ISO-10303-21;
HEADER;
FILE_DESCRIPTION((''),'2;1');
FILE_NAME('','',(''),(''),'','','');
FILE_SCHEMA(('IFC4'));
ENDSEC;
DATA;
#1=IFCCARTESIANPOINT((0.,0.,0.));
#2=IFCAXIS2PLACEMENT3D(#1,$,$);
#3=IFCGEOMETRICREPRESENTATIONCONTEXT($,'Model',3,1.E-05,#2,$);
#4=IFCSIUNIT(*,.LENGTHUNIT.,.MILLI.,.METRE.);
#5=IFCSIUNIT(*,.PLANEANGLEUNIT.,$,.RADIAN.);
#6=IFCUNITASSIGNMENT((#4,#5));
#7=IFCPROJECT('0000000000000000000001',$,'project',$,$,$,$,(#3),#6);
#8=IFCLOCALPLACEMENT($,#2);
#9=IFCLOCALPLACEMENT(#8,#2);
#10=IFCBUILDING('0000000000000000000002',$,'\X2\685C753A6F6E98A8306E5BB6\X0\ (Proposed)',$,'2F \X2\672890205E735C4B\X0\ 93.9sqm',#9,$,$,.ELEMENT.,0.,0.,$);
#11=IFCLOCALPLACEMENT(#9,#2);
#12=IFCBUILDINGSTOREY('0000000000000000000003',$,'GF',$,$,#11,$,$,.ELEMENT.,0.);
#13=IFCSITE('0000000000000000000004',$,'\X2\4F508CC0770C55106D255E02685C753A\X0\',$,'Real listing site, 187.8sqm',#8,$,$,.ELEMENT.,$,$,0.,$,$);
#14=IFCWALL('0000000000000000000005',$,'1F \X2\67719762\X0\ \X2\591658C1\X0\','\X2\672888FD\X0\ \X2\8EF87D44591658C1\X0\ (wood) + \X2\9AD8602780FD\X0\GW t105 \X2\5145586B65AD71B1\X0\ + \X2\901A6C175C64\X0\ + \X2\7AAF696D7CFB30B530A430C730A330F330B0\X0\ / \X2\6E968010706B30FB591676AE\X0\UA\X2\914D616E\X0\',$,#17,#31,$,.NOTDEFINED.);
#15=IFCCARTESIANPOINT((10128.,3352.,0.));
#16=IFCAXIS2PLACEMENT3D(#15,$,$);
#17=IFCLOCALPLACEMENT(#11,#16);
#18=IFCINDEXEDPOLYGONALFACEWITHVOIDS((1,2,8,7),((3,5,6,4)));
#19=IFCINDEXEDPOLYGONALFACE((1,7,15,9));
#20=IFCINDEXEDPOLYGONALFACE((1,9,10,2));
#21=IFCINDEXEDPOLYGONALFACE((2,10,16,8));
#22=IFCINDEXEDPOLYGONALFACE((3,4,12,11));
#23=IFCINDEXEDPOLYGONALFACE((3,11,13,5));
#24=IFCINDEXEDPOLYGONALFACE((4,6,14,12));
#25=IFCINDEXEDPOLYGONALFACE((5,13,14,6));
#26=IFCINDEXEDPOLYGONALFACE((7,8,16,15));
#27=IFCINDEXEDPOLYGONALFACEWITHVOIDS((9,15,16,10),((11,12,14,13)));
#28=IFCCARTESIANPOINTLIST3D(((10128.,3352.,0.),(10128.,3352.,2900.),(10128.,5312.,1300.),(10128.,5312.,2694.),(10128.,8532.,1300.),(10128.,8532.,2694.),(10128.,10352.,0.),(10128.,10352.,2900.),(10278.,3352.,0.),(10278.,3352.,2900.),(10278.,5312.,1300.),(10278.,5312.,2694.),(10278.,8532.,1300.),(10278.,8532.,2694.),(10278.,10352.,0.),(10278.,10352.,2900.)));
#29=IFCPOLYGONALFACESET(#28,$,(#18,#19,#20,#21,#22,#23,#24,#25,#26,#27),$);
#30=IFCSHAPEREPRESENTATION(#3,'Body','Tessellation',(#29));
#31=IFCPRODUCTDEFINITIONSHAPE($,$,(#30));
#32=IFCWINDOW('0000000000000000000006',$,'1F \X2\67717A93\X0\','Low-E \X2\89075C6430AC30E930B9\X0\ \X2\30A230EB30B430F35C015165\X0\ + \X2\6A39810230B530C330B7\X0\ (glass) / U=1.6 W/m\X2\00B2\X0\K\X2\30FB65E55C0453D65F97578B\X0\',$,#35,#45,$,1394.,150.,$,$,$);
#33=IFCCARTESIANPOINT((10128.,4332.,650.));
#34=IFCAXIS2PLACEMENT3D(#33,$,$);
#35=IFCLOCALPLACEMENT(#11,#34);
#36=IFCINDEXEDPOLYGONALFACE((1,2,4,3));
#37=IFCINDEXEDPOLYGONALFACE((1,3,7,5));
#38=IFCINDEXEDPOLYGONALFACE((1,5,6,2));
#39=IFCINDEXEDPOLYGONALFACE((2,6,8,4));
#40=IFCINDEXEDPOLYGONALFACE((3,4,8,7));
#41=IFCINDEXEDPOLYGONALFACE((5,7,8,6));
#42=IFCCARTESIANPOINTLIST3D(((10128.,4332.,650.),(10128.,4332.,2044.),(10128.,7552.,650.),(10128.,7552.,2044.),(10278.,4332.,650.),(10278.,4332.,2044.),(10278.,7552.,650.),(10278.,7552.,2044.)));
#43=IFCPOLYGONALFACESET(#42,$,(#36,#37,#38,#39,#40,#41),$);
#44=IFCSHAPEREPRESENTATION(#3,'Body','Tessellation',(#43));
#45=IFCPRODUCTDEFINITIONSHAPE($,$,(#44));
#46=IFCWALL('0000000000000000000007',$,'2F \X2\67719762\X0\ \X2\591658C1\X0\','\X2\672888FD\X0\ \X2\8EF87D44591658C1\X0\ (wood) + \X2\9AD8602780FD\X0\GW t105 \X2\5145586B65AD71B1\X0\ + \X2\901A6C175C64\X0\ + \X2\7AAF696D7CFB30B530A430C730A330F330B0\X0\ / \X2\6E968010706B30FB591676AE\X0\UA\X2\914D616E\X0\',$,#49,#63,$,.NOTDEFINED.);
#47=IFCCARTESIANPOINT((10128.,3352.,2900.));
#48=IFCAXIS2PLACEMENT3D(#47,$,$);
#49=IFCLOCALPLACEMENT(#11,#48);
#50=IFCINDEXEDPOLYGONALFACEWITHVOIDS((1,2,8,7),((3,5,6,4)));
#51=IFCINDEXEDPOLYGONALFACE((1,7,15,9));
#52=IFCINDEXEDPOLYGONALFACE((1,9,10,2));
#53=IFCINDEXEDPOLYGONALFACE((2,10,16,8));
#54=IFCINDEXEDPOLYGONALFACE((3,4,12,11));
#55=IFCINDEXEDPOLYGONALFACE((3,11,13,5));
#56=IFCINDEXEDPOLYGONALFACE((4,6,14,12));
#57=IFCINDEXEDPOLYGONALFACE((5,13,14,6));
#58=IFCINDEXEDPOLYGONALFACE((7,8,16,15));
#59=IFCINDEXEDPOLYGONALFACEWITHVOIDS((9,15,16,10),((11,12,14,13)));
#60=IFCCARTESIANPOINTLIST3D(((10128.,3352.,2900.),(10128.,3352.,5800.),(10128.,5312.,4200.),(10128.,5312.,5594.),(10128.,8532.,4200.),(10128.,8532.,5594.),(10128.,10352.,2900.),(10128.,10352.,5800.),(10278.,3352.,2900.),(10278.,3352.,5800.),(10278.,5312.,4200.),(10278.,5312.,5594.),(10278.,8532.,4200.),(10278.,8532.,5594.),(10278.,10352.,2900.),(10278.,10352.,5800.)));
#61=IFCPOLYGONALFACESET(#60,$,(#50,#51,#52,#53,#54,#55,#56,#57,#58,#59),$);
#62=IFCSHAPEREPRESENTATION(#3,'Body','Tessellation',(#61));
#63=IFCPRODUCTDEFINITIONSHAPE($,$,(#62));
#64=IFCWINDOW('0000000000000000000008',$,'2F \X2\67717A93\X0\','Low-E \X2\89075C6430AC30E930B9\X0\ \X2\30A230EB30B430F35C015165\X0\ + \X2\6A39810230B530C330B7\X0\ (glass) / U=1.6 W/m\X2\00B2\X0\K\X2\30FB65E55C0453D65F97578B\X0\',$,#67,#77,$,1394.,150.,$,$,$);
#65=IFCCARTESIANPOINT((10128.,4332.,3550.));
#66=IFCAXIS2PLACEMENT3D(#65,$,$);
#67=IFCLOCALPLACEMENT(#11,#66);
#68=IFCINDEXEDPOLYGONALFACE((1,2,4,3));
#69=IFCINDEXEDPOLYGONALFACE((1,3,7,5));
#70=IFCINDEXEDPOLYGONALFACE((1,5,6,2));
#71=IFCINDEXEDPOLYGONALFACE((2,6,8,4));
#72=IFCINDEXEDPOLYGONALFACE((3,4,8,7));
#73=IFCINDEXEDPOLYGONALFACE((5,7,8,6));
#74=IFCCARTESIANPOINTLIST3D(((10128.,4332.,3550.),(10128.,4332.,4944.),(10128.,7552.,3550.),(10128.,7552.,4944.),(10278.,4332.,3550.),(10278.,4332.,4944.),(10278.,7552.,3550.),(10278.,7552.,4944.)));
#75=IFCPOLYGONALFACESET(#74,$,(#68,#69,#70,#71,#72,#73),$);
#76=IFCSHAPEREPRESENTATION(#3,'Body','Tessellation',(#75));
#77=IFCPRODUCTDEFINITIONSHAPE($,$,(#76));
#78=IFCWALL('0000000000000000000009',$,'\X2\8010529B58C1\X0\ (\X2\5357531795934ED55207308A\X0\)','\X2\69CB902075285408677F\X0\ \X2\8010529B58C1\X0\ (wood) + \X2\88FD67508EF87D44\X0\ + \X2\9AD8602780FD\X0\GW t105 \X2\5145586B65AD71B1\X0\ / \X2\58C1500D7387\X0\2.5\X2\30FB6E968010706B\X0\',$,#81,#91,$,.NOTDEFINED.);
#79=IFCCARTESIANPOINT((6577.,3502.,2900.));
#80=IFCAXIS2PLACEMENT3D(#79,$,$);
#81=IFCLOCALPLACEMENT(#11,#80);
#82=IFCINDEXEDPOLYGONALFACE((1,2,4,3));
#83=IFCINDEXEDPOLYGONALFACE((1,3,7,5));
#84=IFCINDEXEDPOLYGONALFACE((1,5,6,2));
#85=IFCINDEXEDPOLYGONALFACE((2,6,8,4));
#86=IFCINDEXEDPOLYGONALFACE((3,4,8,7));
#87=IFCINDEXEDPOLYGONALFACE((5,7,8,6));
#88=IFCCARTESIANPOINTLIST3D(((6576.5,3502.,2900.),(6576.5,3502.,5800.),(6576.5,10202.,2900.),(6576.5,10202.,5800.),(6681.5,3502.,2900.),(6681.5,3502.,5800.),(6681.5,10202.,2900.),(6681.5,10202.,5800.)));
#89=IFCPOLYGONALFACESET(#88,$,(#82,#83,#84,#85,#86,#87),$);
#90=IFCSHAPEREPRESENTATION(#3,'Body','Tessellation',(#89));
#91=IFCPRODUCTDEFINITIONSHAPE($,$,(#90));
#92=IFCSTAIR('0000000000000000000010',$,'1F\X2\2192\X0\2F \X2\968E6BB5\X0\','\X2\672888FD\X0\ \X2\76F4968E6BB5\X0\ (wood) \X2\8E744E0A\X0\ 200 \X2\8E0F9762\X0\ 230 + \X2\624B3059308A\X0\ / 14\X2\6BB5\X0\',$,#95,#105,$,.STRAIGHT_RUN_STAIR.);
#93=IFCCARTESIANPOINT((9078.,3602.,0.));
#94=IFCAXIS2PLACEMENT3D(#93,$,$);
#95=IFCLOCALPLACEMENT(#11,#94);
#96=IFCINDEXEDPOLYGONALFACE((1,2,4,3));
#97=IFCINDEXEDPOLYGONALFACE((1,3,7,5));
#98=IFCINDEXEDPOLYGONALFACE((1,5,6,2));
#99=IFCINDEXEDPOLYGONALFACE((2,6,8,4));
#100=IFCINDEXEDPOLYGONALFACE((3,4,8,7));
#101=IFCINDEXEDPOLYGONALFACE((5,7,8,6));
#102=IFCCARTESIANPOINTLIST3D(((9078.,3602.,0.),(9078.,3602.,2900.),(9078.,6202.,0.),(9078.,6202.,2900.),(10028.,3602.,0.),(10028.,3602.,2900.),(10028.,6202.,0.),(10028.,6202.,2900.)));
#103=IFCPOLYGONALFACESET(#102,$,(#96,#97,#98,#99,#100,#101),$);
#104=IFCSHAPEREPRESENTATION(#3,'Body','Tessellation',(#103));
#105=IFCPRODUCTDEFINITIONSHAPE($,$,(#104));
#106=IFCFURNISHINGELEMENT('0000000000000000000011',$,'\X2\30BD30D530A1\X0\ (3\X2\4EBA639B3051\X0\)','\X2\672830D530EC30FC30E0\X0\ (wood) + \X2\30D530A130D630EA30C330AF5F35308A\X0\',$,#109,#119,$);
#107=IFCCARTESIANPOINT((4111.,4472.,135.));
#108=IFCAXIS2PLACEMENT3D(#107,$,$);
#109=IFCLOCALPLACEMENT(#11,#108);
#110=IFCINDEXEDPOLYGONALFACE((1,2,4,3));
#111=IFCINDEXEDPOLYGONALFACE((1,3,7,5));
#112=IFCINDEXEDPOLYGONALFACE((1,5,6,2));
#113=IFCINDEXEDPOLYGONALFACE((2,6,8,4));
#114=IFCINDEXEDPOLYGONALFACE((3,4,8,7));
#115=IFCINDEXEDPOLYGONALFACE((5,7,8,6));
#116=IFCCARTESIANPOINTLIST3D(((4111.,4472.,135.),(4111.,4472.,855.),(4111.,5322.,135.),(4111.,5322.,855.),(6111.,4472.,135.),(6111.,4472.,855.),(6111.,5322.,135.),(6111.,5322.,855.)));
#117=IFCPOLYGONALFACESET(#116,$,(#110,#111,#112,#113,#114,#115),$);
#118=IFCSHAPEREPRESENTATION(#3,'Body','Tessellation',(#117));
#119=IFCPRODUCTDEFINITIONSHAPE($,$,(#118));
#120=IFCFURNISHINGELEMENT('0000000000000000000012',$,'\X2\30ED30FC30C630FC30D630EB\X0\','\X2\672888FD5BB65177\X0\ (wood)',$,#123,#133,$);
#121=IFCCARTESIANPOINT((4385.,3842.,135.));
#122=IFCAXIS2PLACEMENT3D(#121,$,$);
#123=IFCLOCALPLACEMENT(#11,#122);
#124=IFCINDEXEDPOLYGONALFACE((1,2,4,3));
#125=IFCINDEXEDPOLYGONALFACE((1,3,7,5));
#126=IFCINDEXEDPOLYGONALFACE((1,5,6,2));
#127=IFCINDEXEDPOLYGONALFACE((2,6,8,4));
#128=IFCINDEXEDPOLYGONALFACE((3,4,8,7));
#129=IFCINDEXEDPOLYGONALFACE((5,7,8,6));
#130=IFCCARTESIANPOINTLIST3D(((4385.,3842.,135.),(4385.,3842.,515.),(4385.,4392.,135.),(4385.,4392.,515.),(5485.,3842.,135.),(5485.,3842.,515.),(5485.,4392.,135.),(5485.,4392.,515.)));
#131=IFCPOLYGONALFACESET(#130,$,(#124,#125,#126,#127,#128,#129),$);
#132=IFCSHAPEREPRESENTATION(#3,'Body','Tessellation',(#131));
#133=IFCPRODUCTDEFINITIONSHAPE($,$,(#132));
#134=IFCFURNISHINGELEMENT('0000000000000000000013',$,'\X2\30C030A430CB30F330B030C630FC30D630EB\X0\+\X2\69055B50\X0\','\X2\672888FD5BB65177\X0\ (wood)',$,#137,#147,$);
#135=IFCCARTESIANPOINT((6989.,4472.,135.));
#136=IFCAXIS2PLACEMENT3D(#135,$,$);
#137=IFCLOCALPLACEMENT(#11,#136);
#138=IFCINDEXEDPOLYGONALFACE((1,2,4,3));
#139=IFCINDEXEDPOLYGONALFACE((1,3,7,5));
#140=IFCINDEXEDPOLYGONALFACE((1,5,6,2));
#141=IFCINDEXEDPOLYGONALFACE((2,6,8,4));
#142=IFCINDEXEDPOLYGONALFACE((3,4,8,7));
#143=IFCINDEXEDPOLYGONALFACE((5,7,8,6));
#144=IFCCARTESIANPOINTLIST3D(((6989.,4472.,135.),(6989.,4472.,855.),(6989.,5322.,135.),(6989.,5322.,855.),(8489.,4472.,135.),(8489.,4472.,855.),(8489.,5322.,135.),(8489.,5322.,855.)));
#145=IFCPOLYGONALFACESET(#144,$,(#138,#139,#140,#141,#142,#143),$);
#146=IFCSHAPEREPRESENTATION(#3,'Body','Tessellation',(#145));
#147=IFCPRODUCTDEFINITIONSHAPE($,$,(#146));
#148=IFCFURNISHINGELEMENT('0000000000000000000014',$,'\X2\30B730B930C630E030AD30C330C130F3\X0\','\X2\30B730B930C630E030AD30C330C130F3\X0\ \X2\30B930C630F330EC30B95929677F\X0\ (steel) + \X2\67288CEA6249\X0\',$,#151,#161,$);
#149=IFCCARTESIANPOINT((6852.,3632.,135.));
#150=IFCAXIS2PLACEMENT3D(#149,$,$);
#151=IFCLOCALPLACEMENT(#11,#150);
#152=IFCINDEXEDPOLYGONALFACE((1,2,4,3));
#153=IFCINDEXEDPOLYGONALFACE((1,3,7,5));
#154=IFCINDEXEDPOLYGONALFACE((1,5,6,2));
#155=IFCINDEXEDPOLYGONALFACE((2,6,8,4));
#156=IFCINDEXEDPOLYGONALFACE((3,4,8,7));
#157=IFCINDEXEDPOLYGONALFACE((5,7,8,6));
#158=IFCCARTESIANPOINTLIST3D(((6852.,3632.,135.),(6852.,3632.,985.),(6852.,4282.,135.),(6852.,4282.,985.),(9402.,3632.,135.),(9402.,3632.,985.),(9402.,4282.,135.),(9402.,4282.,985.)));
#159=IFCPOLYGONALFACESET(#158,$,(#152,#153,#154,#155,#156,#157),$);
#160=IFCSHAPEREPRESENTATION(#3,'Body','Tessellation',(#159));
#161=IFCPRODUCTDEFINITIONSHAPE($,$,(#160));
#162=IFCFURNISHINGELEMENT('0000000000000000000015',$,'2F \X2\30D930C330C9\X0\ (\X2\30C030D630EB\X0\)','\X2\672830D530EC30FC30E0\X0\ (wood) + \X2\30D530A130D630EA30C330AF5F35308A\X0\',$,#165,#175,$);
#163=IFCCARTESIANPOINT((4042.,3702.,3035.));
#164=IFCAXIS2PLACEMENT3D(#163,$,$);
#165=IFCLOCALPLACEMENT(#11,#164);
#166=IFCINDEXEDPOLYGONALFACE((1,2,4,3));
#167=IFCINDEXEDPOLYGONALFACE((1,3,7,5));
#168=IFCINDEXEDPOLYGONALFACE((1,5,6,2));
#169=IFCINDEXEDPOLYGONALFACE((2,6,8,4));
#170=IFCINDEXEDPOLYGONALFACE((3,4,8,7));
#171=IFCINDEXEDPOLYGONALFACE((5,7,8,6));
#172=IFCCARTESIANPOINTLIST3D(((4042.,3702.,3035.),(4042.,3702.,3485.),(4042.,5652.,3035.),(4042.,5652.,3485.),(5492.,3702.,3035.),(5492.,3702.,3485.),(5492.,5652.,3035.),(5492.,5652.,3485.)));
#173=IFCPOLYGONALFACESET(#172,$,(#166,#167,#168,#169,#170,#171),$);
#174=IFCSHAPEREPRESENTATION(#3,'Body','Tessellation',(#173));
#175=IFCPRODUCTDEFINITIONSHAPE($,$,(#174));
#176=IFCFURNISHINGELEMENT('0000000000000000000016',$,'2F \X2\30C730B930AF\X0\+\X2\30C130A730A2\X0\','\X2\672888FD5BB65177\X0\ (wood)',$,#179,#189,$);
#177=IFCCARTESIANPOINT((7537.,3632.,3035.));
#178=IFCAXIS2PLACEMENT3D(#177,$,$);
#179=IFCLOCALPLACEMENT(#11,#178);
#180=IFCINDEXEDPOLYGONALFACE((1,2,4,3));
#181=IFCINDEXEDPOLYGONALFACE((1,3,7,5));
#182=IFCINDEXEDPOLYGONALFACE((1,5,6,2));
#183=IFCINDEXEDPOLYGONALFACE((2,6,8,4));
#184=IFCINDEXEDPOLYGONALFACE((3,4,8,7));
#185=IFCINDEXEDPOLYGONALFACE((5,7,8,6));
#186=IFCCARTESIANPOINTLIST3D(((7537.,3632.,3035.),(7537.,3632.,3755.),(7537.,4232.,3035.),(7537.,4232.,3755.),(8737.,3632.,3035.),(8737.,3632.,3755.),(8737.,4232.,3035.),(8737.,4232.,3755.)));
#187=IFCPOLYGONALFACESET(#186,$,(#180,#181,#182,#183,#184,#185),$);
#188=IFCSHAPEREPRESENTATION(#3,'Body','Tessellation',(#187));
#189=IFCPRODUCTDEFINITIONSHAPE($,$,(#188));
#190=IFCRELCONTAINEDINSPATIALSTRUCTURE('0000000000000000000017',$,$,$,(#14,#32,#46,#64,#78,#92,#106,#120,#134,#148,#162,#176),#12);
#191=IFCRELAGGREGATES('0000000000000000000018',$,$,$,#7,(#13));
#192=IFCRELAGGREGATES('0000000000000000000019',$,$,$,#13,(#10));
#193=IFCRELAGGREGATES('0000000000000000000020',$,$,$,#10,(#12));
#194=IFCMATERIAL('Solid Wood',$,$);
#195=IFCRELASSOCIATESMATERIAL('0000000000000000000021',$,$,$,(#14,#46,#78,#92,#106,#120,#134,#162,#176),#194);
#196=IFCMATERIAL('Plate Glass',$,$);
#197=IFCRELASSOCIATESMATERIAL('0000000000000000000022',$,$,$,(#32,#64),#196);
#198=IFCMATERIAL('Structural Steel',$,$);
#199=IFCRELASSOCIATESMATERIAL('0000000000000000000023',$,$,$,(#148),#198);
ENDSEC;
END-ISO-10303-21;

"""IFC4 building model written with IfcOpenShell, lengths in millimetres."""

from ifc_helpers import new_model, si_unit, frame, frame_2d, origin, place, context, project, spatial, rectangle, extrude, material, element, fill, save


model = new_model("IFC4")

# Units and contexts
model_context = context("Model", 3, precision=1e-05, world=origin())
ifc_project = project(units=[si_unit("LENGTHUNIT", "METRE", prefix="MILLI"), si_unit("PLANEANGLEUNIT", "RADIAN")], contexts=[model_context])

# Site, building, storey
site_placement = place(None, origin())
site = spatial("IfcSite", under=ifc_project, at=site_placement, Name="佐賀県唐津市桜町", ObjectType="Real listing site, 187.8sqm", CompositionType="ELEMENT", RefElevation=0.0)
building_placement = place(site_placement, origin())
building = spatial("IfcBuilding", under=site, at=building_placement, Name="桜町潮風の家 (Proposed)", ObjectType="2F 木造平屋 93.9sqm", CompositionType="ELEMENT", ElevationOfRefHeight=0.0, ElevationOfTerrain=0.0)
storey_placement = place(building_placement, origin())
storey = spatial("IfcBuildingStorey", under=building, at=storey_placement, Name="GF", CompositionType="ELEMENT", Elevation=0.0)

# Wall, opening, window
ifc_material_1 = material(Name="Solid Wood")
wall_1_placement = place(storey_placement, frame((10128.0, 3352.0, 0.0)))
wall_1 = element("IfcWall", 1, at=wall_1_placement, inside=storey, material=ifc_material_1, Name="1F 東面 外壁", Description="木製 軸組外壁 (wood) + 高性能GW t105 充填断熱 + 通気層 + 窯業系サイディング / 準耐火・外皮UA配慮", PredefinedType="NOTDEFINED", context=model_context, shape_type="SweptSolid", body=[
    extrude(rectangle(XDim=150.0, YDim=7000.0, at=frame_2d((75.0, 3500.0))), frame((10128.0, 3352.0, 0.0)), (0.0, 0.0, 1.0), 2900.0),
])
opening_1_placement = place(storey_placement, frame((10128.0, 4332.0, 650.0)))
opening_1 = element("IfcOpeningElement", 2, at=opening_1_placement, cuts=wall_1, PredefinedType="NOTDEFINED", context=model_context, shape_type="SweptSolid", body=[
    extrude(rectangle(XDim=150.0, YDim=3220.0, at=frame_2d((75.0, 1610.0))), frame((10128.0, 4332.0, 650.0)), (0.0, 0.0, 1.0), 1394.0),
])
ifc_material_2 = material(Name="Plate Glass")
window_1_placement = place(storey_placement, frame((10128.0, 4332.0, 650.0)))
window_1 = element("IfcWindow", 3, at=window_1_placement, inside=storey, material=ifc_material_2, Name="1F 東窓", Description="Low-E 複層ガラス アルゴン封入 + 樹脂サッシ (glass) / U=1.6 W/m²K・日射取得型", OverallHeight=1394.0, OverallWidth=150.0, context=model_context, shape_type="SweptSolid", body=[
    extrude(rectangle(XDim=150.0, YDim=3220.0, at=frame_2d((75.0, 1610.0))), frame((10128.0, 4332.0, 650.0)), (0.0, 0.0, 1.0), 1394.0),
])
fill(opening_1, window_1)

# Wall, opening, window
wall_2_placement = place(storey_placement, frame((10128.0, 3352.0, 2900.0)))
wall_2 = element("IfcWall", 4, at=wall_2_placement, inside=storey, material=ifc_material_1, Name="2F 東面 外壁", Description="木製 軸組外壁 (wood) + 高性能GW t105 充填断熱 + 通気層 + 窯業系サイディング / 準耐火・外皮UA配慮", PredefinedType="NOTDEFINED", context=model_context, shape_type="SweptSolid", body=[
    extrude(rectangle(XDim=150.0, YDim=7000.0, at=frame_2d((75.0, 3500.0))), frame((10128.0, 3352.0, 2900.0)), (0.0, 0.0, 1.0), 2900.0),
])
opening_2_placement = place(storey_placement, frame((10128.0, 4332.0, 3550.0)))
opening_2 = element("IfcOpeningElement", 5, at=opening_2_placement, cuts=wall_2, PredefinedType="NOTDEFINED", context=model_context, shape_type="SweptSolid", body=[
    extrude(rectangle(XDim=150.0, YDim=3220.0, at=frame_2d((75.0, 1610.0))), frame((10128.0, 4332.0, 3550.0)), (0.0, 0.0, 1.0), 1394.0),
])
window_2_placement = place(storey_placement, frame((10128.0, 4332.0, 3550.0)))
window_2 = element("IfcWindow", 6, at=window_2_placement, inside=storey, material=ifc_material_2, Name="2F 東窓", Description="Low-E 複層ガラス アルゴン封入 + 樹脂サッシ (glass) / U=1.6 W/m²K・日射取得型", OverallHeight=1394.0, OverallWidth=150.0, context=model_context, shape_type="SweptSolid", body=[
    extrude(rectangle(XDim=150.0, YDim=3220.0, at=frame_2d((75.0, 1610.0))), frame((10128.0, 4332.0, 3550.0)), (0.0, 0.0, 1.0), 1394.0),
])
fill(opening_2, window_2)

# Wall
wall_3_placement = place(storey_placement, frame((6577.0, 3502.0, 2900.0)))
element("IfcWall", 7, at=wall_3_placement, inside=storey, material=ifc_material_1, Name="耐力壁 (南北間仕切り)", Description="構造用合板 耐力壁 (wood) + 製材軸組 + 高性能GW t105 充填断熱 / 壁倍率2.5・準耐火", PredefinedType="NOTDEFINED", context=model_context, shape_type="SweptSolid", body=[
    extrude(rectangle(XDim=105.0, YDim=6700.0, at=frame_2d((52.0, 3350.0))), frame((6577.0, 3502.0, 2900.0)), (0.0, 0.0, 1.0), 2900.0),
])

# Stair
stair_placement = place(storey_placement, frame((9078.0, 3602.0, 0.0)))
element("IfcStair", 8, at=stair_placement, inside=storey, material=ifc_material_1, Name="1F→2F 階段", Description="木製 直階段 (wood) 蹴上 200 踏面 230 + 手すり / 14段", PredefinedType="STRAIGHT_RUN_STAIR", context=model_context, shape_type="SweptSolid", body=[
    extrude(rectangle(XDim=950.0, YDim=2600.0, at=frame_2d((475.0, 1300.0))), frame((9078.0, 3602.0, 0.0)), (0.0, 0.0, 1.0), 2900.0),
])

# Furnishing elements
furnishing_1_placement = place(storey_placement, frame((4111.0, 4472.0, 135.0)))
element("IfcFurnishingElement", 9, at=furnishing_1_placement, inside=storey, material=ifc_material_1, Name="ソファ (3人掛け)", Description="木フレーム (wood) + ファブリック張り", context=model_context, shape_type="SweptSolid", body=[
    extrude(rectangle(XDim=2000.0, YDim=850.0, at=frame_2d((1000.0, 425.0))), frame((4111.0, 4472.0, 135.0)), (0.0, 0.0, 1.0), 720.0),
])
furnishing_2_placement = place(storey_placement, frame((4385.0, 3842.0, 135.0)))
element("IfcFurnishingElement", 10, at=furnishing_2_placement, inside=storey, material=ifc_material_1, Name="ローテーブル", Description="木製家具 (wood)", context=model_context, shape_type="SweptSolid", body=[
    extrude(rectangle(XDim=1100.0, YDim=550.0, at=frame_2d((550.0, 275.0))), frame((4385.0, 3842.0, 135.0)), (0.0, 0.0, 1.0), 380.0),
])
furnishing_3_placement = place(storey_placement, frame((6989.0, 4472.0, 135.0)))
element("IfcFurnishingElement", 11, at=furnishing_3_placement, inside=storey, material=ifc_material_1, Name="ダイニングテーブル+椅子", Description="木製家具 (wood)", context=model_context, shape_type="SweptSolid", body=[
    extrude(rectangle(XDim=1500.0, YDim=850.0, at=frame_2d((750.0, 425.0))), frame((6989.0, 4472.0, 135.0)), (0.0, 0.0, 1.0), 720.0),
])
ifc_material_3 = material(Name="Structural Steel")
furnishing_4_placement = place(storey_placement, frame((6852.0, 3632.0, 135.0)))
element("IfcFurnishingElement", 12, at=furnishing_4_placement, inside=storey, material=ifc_material_3, Name="システムキッチン", Description="システムキッチン ステンレス天板 (steel) + 木質扉", context=model_context, shape_type="SweptSolid", body=[
    extrude(rectangle(XDim=2550.0, YDim=650.0, at=frame_2d((1275.0, 325.0))), frame((6852.0, 3632.0, 135.0)), (0.0, 0.0, 1.0), 850.0),
])
furnishing_5_placement = place(storey_placement, frame((4042.0, 3702.0, 3035.0)))
element("IfcFurnishingElement", 13, at=furnishing_5_placement, inside=storey, material=ifc_material_1, Name="2F ベッド (ダブル)", Description="木フレーム (wood) + ファブリック張り", context=model_context, shape_type="SweptSolid", body=[
    extrude(rectangle(XDim=1450.0, YDim=1950.0, at=frame_2d((725.0, 975.0))), frame((4042.0, 3702.0, 3035.0)), (0.0, 0.0, 1.0), 450.0),
])
furnishing_6_placement = place(storey_placement, frame((7537.0, 3632.0, 3035.0)))
element("IfcFurnishingElement", 14, at=furnishing_6_placement, inside=storey, material=ifc_material_1, Name="2F デスク+チェア", Description="木製家具 (wood)", context=model_context, shape_type="SweptSolid", body=[
    extrude(rectangle(XDim=1200.0, YDim=600.0, at=frame_2d((600.0, 300.0))), frame((7537.0, 3632.0, 3035.0)), (0.0, 0.0, 1.0), 720.0),
])

save(model, "model.ifc")
